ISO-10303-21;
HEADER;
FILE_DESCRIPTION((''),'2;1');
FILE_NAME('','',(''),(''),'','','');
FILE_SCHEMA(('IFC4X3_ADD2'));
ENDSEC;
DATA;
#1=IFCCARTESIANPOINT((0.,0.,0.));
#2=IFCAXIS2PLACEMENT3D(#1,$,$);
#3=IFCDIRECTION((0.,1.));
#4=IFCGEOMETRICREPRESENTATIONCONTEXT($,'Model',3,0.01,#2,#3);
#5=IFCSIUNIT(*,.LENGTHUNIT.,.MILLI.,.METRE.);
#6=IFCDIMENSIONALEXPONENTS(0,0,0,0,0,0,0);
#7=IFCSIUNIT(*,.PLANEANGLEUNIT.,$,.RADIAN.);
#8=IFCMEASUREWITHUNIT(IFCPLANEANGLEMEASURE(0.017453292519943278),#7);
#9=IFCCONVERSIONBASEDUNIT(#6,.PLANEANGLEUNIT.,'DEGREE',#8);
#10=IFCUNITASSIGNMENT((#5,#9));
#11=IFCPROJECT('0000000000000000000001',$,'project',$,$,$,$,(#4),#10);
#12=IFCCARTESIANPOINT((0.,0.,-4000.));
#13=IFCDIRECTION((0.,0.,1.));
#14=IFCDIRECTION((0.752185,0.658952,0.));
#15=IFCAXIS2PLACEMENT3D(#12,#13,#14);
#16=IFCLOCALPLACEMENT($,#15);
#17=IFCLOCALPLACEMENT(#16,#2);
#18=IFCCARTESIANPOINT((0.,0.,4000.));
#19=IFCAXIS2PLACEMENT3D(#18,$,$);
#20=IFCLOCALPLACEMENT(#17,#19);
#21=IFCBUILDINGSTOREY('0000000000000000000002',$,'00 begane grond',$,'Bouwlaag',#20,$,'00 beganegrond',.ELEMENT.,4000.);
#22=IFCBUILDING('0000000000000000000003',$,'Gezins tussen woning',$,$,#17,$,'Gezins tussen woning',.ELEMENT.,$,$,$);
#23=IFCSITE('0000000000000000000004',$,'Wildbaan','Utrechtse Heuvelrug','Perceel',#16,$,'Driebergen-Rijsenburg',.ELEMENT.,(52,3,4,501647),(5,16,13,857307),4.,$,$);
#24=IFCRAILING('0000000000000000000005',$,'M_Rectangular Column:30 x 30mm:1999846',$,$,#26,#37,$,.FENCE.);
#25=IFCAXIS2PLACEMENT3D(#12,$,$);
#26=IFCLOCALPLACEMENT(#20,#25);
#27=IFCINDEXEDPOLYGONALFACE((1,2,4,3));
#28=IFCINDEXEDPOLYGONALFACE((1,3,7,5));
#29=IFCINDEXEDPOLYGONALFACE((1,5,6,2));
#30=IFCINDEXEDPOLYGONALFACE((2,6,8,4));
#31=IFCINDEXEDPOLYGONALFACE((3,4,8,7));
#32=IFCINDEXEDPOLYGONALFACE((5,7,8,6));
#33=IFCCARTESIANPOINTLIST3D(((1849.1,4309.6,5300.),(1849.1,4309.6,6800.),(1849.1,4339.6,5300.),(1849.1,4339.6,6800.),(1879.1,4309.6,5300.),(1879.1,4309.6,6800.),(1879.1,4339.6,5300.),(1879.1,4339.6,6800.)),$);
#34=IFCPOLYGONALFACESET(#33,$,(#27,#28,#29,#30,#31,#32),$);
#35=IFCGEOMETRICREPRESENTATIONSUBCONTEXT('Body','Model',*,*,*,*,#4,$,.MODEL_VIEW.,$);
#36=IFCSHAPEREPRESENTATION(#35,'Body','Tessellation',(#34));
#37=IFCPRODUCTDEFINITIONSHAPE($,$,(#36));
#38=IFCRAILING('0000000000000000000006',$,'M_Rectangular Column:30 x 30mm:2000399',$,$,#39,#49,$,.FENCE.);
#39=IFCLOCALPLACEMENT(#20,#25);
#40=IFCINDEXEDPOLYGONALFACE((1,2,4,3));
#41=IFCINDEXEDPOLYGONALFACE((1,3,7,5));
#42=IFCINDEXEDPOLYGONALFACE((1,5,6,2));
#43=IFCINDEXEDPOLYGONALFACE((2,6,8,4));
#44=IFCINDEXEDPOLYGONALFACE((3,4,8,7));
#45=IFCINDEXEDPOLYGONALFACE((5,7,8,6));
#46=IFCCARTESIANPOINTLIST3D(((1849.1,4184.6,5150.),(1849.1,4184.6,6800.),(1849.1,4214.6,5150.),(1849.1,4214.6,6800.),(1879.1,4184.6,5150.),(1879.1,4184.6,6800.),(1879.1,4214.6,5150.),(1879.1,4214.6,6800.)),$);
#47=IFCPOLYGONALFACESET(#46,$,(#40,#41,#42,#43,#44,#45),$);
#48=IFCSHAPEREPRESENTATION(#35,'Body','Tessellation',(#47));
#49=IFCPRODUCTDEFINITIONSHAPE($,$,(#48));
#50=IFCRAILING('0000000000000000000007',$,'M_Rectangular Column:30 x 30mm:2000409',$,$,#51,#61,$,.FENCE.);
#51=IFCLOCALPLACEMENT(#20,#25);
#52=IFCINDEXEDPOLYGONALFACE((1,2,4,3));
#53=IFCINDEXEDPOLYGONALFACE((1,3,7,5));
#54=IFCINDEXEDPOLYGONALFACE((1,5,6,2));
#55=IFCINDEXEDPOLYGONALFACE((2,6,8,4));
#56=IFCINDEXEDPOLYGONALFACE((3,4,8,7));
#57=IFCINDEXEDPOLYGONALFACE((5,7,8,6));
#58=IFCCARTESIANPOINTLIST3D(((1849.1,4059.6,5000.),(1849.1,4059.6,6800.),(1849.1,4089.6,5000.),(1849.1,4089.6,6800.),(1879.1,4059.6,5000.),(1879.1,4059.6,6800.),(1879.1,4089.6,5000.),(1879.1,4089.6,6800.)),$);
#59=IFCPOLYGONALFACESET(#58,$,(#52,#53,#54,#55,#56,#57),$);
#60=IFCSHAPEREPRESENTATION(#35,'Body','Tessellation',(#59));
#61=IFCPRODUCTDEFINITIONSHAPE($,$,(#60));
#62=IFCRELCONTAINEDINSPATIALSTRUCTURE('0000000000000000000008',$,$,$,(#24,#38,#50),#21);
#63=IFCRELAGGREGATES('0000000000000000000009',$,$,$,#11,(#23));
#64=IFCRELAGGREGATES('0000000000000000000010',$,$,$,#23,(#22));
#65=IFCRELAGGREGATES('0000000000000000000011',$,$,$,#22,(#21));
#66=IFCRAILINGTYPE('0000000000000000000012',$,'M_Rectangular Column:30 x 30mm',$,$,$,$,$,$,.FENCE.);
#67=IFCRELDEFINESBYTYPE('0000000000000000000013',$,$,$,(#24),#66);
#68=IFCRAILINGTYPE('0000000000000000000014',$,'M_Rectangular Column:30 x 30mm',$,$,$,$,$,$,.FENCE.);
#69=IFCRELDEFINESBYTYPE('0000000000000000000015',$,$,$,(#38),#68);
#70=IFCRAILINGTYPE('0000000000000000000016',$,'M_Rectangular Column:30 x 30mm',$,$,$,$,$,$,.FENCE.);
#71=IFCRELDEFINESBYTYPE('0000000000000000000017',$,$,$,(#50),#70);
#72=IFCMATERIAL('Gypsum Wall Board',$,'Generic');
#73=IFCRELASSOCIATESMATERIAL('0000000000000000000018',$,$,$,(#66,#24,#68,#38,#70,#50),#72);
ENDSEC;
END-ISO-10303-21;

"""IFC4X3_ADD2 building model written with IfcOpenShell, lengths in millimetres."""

from ifc_helpers import new_model, entity, si_unit, converted_unit, direction, frame, frame_2d, origin, place, context, subcontext, project, spatial, rectangle, extrude, source, transform, mapped, material, type_object, type_shapes, element, save


model = new_model("IFC4X3_ADD2")

# Units and contexts
model_context = context("Model", 3, precision=0.01, world=origin(), true_north=direction((0.0, 1.0)))
body_context = subcontext(model_context, "Body", "Model", "MODEL_VIEW")
ifc_project = project(units=[si_unit("LENGTHUNIT", "METRE", prefix="MILLI"), converted_unit("PLANEANGLEUNIT", "DEGREE", entity("IfcPlaneAngleMeasure", 0.017453292519943278), si_unit("PLANEANGLEUNIT", "RADIAN"), dimensions=[0, 0, 0, 0, 0, 0, 0])], contexts=[model_context])

# Site, building, storey
site_placement = place(None, frame((0.0, 0.0, -4000.0), z_axis=(0.0, 0.0, 1.0), x_axis=(0.752185, 0.658952, 0.0)))
site = spatial("IfcSite", under=ifc_project, at=site_placement, Name="Wildbaan", Description="Utrechtse Heuvelrug", ObjectType="Perceel", LongName="Driebergen-Rijsenburg", CompositionType="ELEMENT", RefLatitude=(52, 3, 4, 501647), RefLongitude=(5, 16, 13, 857307), RefElevation=4.0)
building_placement = place(site_placement, origin())
building = spatial("IfcBuilding", under=site, at=building_placement, Name="Gezins tussen woning", LongName="Gezins tussen woning", CompositionType="ELEMENT")
storey_placement = place(building_placement, frame((0.0, 0.0, 4000.0)))
storey = spatial("IfcBuildingStorey", under=building, at=storey_placement, Name="00 begane grond", ObjectType="Bouwlaag", LongName="00 beganegrond", CompositionType="ELEMENT", Elevation=4000.0)

# Shared definitions
ifc_material_1 = material(Name="Gypsum Wall Board", Category="Generic")

# Railings
railing_type_1 = type_object("IfcRailingType", Name="M_Rectangular Column:30 x 30mm", PredefinedType="FENCE", material=ifc_material_1)
shared_shape_1 = source(origin(), body_context, "Body", "SweptSolid", [
    extrude(rectangle(XDim=30.0, YDim=30.0, at=frame_2d((0.0, 0.0), x_axis=(1.0, 0.0))), frame((1864.1, 4324.6, 5300.0), z_axis=(0.0, 0.0, 1.0), x_axis=(-1.0, 0.0, 0.0)), (0.0, 0.0, 1.0), 1500.0),
])
type_shapes(railing_type_1, [shared_shape_1])
railing_1_placement = place(storey_placement, frame((0.0, 0.0, -4000.0)))
element("IfcRailing", 1, at=railing_1_placement, inside=storey, type_object=railing_type_1, material=ifc_material_1, Name="M_Rectangular Column:30 x 30mm:1999846", PredefinedType="FENCE", context=body_context, shape_type="MappedRepresentation", body=[
    mapped(shared_shape_1, transform((0.0, 0.0, 0.0), scale=1.0)),
])
railing_type_2 = type_object("IfcRailingType", Name="M_Rectangular Column:30 x 30mm", PredefinedType="FENCE", material=ifc_material_1)
shared_shape_2 = source(origin(), body_context, "Body", "SweptSolid", [
    extrude(rectangle(XDim=30.0, YDim=30.0, at=frame_2d((0.0, 0.0), x_axis=(1.0, 0.0))), frame((1864.1, 4199.6, 5150.0), z_axis=(0.0, 0.0, 1.0), x_axis=(-1.0, 0.0, 0.0)), (0.0, 0.0, 1.0), 1650.0),
])
type_shapes(railing_type_2, [shared_shape_2])
railing_2_placement = place(storey_placement, frame((0.0, 0.0, -4000.0)))
element("IfcRailing", 2, at=railing_2_placement, inside=storey, type_object=railing_type_2, material=ifc_material_1, Name="M_Rectangular Column:30 x 30mm:2000399", PredefinedType="FENCE", context=body_context, shape_type="MappedRepresentation", body=[
    mapped(shared_shape_2, transform((0.0, 0.0, 0.0), scale=1.0)),
])
railing_type_3 = type_object("IfcRailingType", Name="M_Rectangular Column:30 x 30mm", PredefinedType="FENCE", material=ifc_material_1)
shared_shape_3 = source(origin(), body_context, "Body", "SweptSolid", [
    extrude(rectangle(XDim=30.0, YDim=30.0, at=frame_2d((0.0, 0.0), x_axis=(1.0, 0.0))), frame((1864.1, 4074.6, 5000.0), z_axis=(0.0, 0.0, 1.0), x_axis=(-1.0, 0.0, 0.0)), (0.0, 0.0, 1.0), 1800.0),
])
type_shapes(railing_type_3, [shared_shape_3])
railing_3_placement = place(storey_placement, frame((0.0, 0.0, -4000.0)))
element("IfcRailing", 3, at=railing_3_placement, inside=storey, type_object=railing_type_3, material=ifc_material_1, Name="M_Rectangular Column:30 x 30mm:2000409", PredefinedType="FENCE", context=body_context, shape_type="MappedRepresentation", body=[
    mapped(shared_shape_3, transform((0.0, 0.0, 0.0), scale=1.0)),
])

save(model, "model.ifc")
